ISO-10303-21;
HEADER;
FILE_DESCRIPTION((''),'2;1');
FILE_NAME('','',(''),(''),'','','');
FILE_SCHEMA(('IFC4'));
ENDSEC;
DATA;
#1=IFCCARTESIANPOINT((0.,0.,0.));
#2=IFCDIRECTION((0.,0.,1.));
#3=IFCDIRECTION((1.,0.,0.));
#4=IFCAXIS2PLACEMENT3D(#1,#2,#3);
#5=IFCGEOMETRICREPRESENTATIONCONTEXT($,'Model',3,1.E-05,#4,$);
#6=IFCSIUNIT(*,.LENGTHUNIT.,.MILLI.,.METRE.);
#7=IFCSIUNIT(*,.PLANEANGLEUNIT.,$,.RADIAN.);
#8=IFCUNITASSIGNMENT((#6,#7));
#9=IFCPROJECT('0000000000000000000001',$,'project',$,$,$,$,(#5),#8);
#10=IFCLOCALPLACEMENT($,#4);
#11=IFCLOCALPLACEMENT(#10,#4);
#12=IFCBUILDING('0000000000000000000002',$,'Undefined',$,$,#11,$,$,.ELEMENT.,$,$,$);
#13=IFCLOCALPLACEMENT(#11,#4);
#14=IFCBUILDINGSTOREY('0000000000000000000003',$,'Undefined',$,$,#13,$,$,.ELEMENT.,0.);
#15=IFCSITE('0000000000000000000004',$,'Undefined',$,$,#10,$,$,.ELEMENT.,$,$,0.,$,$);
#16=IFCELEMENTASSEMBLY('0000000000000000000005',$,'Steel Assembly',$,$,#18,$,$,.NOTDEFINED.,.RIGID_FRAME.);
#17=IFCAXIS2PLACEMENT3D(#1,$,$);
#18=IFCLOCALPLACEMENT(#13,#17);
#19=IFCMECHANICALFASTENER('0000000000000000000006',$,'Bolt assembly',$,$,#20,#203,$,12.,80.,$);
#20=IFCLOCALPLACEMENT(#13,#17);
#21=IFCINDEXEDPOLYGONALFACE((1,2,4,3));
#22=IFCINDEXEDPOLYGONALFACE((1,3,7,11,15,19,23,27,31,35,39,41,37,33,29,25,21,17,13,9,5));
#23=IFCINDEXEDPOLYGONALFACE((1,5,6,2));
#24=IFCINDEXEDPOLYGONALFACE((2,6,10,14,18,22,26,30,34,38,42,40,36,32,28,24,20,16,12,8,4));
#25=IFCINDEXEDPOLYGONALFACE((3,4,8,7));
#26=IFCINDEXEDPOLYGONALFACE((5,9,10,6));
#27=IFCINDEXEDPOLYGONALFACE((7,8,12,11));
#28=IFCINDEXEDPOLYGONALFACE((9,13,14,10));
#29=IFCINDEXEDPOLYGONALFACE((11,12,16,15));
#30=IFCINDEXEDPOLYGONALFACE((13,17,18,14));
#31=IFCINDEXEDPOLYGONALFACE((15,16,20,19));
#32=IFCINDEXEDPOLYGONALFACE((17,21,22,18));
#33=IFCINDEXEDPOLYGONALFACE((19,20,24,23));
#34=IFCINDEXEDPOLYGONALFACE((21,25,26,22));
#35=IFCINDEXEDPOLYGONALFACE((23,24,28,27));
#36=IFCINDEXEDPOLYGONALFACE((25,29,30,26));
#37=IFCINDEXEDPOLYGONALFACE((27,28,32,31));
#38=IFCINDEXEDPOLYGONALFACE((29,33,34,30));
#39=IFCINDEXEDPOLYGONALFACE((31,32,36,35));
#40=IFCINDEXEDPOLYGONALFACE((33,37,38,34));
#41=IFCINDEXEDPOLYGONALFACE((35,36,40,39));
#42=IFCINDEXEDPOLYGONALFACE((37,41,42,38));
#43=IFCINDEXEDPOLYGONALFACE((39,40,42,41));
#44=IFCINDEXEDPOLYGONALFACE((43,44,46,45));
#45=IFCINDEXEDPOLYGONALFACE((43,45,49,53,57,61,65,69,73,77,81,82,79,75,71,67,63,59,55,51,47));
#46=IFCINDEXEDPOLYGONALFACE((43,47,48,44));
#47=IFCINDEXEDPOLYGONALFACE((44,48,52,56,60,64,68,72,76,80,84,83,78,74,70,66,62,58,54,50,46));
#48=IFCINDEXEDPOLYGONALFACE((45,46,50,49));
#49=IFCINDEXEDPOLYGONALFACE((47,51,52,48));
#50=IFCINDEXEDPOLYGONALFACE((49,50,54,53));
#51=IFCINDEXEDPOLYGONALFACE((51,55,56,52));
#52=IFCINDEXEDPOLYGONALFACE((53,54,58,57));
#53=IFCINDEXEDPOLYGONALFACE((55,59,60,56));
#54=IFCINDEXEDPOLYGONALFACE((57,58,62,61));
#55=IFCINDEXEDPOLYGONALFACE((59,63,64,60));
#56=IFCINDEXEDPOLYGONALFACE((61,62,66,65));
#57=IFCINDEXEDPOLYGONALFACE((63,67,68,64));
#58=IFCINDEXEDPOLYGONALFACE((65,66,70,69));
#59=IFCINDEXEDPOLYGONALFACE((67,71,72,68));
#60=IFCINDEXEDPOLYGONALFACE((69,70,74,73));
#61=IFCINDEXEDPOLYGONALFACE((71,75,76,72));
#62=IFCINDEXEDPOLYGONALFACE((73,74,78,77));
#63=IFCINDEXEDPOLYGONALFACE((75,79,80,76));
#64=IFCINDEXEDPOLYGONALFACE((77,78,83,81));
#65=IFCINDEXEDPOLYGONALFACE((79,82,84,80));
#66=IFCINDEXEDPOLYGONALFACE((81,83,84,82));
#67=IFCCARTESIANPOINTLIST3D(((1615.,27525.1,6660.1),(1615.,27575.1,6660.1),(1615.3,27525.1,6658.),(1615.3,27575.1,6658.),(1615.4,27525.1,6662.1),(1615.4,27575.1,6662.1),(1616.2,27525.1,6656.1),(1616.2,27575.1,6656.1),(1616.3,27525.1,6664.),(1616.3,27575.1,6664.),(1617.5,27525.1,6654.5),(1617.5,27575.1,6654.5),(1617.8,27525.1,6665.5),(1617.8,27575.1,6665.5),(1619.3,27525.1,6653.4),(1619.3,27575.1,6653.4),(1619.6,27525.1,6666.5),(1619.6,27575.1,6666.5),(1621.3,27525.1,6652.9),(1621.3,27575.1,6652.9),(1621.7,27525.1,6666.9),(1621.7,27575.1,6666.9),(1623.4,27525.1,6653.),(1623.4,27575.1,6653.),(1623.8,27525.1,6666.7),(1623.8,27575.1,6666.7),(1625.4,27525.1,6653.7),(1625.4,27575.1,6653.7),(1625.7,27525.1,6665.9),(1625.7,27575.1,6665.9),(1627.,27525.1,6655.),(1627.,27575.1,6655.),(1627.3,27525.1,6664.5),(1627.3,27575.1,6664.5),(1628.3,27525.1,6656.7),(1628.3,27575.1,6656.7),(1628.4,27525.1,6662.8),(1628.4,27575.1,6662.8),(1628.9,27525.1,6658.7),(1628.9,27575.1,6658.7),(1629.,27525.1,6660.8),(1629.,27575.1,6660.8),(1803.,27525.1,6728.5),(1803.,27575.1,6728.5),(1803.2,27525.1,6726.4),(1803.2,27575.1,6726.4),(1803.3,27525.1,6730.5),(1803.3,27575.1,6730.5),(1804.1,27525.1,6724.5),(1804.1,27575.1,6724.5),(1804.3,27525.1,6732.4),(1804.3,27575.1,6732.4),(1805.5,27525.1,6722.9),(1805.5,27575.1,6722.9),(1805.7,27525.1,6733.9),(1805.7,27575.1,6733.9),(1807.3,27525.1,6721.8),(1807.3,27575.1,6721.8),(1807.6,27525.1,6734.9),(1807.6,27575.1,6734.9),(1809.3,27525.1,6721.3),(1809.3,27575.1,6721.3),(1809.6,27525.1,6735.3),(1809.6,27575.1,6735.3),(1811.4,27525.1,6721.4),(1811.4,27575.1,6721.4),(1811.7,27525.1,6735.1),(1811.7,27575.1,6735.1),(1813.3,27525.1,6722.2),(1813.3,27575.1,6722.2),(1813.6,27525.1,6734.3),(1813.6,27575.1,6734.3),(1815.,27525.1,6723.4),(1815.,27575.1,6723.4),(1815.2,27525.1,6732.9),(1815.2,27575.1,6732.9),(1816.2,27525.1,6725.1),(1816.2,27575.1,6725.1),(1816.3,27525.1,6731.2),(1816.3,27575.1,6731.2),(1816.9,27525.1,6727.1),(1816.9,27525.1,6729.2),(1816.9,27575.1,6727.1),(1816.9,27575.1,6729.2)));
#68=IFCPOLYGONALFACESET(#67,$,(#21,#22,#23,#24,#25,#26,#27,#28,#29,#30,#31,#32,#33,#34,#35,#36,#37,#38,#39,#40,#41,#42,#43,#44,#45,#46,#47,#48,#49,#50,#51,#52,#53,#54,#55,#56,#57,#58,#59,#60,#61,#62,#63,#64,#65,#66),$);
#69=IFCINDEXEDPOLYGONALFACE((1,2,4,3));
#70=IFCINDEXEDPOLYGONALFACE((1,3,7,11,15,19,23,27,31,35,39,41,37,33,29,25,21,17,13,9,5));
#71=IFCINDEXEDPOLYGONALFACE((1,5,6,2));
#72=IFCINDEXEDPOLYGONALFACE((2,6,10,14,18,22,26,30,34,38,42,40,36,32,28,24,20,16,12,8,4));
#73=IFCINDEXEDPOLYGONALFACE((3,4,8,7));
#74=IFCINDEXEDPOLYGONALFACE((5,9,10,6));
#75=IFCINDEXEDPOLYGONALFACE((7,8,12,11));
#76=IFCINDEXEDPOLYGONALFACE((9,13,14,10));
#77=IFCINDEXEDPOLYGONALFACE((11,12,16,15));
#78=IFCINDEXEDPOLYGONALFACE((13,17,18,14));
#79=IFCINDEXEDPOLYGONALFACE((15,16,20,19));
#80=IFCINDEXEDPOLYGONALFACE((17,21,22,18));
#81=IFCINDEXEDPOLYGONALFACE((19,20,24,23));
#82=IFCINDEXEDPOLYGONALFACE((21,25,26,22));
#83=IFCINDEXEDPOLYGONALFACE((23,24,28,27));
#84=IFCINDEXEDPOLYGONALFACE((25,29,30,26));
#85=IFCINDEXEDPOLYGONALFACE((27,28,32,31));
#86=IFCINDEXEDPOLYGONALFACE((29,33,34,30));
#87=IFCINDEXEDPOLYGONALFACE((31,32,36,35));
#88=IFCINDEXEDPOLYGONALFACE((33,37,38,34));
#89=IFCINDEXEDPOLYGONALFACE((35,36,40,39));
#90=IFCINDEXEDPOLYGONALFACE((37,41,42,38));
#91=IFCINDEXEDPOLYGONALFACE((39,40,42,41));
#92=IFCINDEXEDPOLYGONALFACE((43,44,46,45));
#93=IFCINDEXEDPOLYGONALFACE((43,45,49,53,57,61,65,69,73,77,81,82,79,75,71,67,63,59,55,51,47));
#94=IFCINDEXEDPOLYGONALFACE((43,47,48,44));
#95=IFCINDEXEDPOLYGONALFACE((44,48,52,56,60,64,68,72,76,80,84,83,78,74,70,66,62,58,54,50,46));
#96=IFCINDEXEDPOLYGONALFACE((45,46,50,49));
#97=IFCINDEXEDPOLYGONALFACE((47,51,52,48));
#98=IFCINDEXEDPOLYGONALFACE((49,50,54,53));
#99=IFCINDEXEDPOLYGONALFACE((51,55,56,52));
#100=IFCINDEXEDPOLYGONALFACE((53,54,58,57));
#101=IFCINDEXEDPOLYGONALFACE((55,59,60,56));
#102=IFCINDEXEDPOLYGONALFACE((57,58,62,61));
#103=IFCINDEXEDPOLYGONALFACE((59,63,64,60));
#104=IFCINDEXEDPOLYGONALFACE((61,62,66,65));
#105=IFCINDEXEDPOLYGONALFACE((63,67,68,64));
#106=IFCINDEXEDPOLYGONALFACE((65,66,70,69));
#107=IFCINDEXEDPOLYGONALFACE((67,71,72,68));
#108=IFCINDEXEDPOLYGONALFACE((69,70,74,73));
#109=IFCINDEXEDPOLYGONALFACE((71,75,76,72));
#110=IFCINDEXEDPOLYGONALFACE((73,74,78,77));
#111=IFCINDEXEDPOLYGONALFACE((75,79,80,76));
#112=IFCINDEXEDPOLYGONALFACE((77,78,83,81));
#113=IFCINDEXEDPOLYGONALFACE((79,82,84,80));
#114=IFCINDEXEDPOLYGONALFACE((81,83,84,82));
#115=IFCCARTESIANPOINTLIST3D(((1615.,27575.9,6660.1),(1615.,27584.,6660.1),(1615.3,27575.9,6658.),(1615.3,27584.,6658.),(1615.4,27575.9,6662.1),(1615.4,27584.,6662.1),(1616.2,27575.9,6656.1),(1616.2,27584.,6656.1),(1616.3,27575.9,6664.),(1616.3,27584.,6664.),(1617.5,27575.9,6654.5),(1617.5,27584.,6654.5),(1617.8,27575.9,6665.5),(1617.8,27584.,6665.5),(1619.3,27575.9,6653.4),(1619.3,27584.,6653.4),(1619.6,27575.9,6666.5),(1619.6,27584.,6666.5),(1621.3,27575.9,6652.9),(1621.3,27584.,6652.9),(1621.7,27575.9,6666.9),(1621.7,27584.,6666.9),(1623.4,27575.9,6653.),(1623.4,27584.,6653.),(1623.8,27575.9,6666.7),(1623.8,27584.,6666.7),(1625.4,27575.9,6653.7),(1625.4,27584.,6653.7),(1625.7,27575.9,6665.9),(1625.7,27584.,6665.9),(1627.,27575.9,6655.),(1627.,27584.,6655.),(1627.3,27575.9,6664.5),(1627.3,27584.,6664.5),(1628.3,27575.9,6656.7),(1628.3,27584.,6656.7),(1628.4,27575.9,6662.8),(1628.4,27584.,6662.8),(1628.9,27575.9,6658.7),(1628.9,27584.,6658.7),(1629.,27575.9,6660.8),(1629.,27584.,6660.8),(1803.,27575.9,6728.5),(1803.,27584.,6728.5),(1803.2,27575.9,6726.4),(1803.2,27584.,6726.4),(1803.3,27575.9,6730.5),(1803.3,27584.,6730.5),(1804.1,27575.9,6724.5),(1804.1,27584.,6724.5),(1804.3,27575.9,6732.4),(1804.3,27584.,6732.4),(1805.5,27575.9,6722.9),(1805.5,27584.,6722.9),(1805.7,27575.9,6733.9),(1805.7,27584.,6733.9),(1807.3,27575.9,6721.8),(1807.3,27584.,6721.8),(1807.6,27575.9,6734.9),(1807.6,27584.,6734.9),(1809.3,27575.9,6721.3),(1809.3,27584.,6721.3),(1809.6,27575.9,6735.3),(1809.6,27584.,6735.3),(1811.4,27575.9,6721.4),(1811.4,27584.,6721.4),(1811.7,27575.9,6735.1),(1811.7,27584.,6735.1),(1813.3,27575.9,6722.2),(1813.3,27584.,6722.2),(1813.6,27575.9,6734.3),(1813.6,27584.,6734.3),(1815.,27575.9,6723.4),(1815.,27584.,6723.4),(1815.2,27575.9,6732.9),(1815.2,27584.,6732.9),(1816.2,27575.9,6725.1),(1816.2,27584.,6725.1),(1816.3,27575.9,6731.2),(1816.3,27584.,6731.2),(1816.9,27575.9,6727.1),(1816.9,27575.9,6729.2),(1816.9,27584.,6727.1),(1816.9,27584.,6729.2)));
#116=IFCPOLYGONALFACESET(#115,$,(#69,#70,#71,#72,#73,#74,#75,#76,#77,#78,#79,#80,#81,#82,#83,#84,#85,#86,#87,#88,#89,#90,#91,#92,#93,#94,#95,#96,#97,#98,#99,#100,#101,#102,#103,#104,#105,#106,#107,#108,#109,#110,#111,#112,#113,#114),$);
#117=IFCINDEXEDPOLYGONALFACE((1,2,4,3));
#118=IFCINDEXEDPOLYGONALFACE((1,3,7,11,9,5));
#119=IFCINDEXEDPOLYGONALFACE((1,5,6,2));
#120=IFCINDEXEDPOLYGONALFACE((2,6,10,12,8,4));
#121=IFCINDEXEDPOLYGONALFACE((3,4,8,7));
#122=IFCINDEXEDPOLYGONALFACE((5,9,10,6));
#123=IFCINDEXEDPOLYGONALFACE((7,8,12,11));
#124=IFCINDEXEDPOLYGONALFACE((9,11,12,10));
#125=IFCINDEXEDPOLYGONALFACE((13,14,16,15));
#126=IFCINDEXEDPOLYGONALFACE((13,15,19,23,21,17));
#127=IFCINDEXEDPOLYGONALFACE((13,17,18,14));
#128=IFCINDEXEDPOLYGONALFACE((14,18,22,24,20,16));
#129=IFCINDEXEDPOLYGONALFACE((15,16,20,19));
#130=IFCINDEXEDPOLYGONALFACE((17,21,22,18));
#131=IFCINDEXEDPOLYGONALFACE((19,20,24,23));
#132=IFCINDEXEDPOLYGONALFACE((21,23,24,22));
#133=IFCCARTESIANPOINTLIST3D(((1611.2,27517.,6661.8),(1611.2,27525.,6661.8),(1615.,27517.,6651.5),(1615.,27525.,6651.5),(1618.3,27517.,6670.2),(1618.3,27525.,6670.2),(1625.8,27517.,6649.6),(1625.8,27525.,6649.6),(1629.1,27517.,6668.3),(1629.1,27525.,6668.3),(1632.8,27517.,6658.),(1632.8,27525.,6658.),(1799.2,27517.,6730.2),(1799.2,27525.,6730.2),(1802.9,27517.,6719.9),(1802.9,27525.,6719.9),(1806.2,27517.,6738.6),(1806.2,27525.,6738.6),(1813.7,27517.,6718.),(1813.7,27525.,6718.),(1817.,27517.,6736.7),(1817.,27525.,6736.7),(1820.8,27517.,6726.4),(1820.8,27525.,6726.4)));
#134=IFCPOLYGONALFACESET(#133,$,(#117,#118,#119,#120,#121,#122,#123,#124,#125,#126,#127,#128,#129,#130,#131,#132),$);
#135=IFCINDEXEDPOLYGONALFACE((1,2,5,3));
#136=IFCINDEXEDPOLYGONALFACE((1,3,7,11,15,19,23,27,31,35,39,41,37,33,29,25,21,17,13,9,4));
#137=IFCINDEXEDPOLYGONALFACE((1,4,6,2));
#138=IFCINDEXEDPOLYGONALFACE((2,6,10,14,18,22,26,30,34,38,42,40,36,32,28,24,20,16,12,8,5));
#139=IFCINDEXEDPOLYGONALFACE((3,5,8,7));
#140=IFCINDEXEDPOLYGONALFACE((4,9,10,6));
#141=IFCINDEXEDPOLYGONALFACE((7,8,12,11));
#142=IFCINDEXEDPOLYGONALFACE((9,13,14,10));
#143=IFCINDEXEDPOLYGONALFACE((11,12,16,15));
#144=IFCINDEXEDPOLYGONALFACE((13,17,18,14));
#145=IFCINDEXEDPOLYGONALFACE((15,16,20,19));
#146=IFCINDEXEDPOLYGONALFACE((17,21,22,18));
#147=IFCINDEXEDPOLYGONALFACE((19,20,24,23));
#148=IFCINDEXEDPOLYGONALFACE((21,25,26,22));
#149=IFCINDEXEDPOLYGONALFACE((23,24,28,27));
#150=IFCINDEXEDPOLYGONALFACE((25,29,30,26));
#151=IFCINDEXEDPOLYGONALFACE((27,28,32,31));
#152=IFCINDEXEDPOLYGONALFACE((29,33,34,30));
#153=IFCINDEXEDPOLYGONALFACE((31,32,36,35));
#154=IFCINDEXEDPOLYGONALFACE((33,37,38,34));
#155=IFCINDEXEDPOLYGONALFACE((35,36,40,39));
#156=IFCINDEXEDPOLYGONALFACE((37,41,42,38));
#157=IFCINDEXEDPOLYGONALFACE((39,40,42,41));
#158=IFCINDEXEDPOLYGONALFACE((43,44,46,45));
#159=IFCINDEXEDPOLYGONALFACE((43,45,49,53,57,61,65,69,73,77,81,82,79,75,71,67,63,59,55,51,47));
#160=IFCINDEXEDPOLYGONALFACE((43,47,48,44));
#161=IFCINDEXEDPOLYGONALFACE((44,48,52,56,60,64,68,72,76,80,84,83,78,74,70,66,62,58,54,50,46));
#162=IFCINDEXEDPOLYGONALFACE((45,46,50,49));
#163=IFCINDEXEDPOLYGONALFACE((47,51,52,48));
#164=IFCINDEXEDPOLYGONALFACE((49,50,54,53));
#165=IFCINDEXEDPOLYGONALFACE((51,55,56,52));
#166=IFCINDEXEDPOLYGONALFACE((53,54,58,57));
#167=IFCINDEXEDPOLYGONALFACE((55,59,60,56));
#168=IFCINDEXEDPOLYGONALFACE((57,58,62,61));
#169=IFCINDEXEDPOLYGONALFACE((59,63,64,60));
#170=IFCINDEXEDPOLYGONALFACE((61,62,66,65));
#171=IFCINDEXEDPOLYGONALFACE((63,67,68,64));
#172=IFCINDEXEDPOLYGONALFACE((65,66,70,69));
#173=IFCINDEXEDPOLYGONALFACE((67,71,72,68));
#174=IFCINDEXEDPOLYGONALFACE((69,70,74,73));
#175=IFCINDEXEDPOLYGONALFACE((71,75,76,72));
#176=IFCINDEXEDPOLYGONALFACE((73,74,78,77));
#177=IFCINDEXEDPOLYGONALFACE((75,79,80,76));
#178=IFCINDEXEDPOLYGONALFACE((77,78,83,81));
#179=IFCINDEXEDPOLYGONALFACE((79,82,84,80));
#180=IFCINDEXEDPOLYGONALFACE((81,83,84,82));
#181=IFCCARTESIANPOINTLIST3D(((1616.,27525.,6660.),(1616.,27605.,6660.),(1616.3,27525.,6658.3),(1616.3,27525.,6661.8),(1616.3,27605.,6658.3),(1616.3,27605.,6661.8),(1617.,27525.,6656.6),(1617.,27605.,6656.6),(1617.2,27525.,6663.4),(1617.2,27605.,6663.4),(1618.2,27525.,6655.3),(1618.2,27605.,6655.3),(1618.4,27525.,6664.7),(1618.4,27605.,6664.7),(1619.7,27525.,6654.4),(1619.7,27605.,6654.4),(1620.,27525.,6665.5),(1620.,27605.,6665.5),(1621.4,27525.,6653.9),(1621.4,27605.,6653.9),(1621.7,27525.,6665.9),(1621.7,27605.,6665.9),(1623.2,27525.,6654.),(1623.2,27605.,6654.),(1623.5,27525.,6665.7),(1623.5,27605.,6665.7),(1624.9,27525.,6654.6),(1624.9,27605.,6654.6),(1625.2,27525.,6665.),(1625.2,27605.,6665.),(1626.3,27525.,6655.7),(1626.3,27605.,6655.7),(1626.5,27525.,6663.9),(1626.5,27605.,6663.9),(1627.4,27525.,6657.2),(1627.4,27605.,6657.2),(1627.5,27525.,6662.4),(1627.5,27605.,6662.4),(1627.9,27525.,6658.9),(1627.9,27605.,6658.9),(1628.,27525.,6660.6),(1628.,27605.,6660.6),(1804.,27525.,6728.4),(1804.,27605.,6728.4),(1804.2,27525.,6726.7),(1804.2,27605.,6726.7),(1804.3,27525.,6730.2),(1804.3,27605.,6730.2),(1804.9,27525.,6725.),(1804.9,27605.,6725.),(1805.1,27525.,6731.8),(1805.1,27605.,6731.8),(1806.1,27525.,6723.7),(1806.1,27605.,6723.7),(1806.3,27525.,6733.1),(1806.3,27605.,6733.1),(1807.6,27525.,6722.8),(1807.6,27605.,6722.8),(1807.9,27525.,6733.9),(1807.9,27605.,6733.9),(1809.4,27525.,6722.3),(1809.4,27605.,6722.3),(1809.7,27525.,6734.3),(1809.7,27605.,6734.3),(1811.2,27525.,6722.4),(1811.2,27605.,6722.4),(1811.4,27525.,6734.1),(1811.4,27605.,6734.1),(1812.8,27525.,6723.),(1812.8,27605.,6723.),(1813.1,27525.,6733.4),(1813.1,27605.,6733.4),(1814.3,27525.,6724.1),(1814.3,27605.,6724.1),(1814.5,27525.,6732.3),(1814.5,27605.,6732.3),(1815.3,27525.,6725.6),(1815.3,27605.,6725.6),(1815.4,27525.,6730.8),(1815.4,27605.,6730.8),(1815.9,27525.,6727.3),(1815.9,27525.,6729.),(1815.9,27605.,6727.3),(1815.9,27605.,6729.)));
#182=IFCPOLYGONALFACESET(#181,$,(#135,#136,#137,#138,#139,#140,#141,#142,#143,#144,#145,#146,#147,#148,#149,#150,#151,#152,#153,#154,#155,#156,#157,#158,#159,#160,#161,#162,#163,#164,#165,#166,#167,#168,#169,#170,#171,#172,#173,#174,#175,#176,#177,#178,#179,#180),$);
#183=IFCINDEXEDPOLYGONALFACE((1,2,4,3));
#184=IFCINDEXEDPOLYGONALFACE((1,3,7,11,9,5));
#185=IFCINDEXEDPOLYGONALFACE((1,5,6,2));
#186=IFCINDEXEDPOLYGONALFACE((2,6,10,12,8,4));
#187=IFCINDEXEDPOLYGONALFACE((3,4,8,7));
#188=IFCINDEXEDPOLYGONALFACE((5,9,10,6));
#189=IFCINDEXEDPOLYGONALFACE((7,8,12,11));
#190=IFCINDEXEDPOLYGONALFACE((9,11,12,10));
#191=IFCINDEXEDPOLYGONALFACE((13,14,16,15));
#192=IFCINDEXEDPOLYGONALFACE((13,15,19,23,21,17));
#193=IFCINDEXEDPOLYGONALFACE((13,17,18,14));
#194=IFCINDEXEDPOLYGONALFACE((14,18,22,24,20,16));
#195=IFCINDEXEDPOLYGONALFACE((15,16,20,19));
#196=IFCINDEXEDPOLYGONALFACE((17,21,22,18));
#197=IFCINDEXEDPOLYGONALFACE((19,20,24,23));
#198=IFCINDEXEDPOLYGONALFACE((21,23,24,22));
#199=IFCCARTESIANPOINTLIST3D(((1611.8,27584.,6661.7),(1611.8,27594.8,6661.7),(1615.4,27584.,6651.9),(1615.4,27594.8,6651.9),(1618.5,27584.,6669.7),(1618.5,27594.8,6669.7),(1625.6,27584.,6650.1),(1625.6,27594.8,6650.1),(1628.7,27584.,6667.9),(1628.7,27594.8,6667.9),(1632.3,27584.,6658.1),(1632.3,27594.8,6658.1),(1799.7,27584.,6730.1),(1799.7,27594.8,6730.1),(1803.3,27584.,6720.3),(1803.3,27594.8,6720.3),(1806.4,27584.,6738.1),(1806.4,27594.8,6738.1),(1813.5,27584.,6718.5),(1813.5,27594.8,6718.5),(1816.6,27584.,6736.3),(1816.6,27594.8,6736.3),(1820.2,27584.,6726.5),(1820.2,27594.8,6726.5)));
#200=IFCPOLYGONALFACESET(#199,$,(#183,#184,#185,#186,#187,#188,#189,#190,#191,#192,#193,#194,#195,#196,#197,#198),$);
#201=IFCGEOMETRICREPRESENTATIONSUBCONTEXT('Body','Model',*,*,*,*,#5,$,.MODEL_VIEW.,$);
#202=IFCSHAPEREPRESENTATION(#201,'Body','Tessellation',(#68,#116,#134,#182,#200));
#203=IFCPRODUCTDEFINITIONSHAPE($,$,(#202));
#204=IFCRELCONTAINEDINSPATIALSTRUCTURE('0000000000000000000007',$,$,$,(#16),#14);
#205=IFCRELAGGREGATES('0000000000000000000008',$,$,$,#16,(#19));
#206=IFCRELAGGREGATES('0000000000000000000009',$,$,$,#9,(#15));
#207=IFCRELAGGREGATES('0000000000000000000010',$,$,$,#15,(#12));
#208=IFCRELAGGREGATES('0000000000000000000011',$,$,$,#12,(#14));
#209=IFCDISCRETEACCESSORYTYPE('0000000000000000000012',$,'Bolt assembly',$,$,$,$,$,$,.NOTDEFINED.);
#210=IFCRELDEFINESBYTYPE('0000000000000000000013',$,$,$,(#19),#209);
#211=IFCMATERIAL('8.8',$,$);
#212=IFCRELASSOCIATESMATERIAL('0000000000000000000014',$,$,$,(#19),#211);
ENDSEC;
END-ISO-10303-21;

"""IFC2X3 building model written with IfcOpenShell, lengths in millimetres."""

from ifc_helpers import new_model, si_unit, frame, origin_with_axes, origin_2d_with_axis, place, context, subcontext, project, spatial, polyline, circle, outline, extrude, source, transform, mapped, material, type_object, element, aggregate, save


model = new_model("IFC2X3")

# Units and contexts
model_context = context("Model", 3, precision=1e-05, world=origin_with_axes())
body_context = subcontext(model_context, "Body", "Model", "MODEL_VIEW")
ifc_project = project(units=[si_unit("LENGTHUNIT", "METRE", prefix="MILLI"), si_unit("PLANEANGLEUNIT", "RADIAN")], contexts=[model_context])

# Site, building, storey
site_placement = place(None, origin_with_axes())
site = spatial("IfcSite", under=ifc_project, at=site_placement, Name="Undefined", CompositionType="ELEMENT", RefElevation=0.0)
building_placement = place(site_placement, origin_with_axes())
building = spatial("IfcBuilding", under=site, at=building_placement, Name="Undefined", CompositionType="ELEMENT")
storey_placement = place(building_placement, origin_with_axes())
storey = spatial("IfcBuildingStorey", under=building, at=storey_placement, Name="Undefined", CompositionType="ELEMENT", Elevation=0.0)

# Element assembly, mechanical fastener
assembly_1_placement = place(storey_placement, origin_with_axes())
assembly_1 = element("IfcElementAssembly", 1, at=assembly_1_placement, inside=storey, Name="Steel Assembly", AssemblyPlace="NOTDEFINED", PredefinedType="RIGID_FRAME")
ifc_material_1 = material(Name="8.8")
discrete_accessory_type_1 = type_object("IfcDiscreteAccessoryType", Name="Bolt assembly")
shared_shape_1 = source(origin_with_axes(), body_context, "Body", "SweptSolid", [
    extrude(circle(Radius=7.0, at=origin_2d_with_axis()), frame((0.0, -52.9, 0.0), z_axis=(0.0, 1.0, 0.0), x_axis=(1.0, 0.0, 0.0)), (0.0, 0.0, 1.0), 50.0),
    extrude(circle(Radius=7.0, at=origin_2d_with_axis()), frame((0.0, -2.1, 0.0), z_axis=(0.0, 1.0, 0.0), x_axis=(1.0, 0.0, 0.0)), (0.0, 0.0, 1.0), 8.1),
    extrude(outline(polyline([(11.0, 0.0), (5.5, 9.5), (-5.5, 9.5), (-11.0, 0.0), (-5.5, -9.5), (5.5, -9.5), (11.0, 0.0)])), frame((0.0, -61.0, 0.0), z_axis=(0.0, 1.0, 0.0), x_axis=(1.0, 0.0, 0.0)), (0.0, 0.0, 1.0), 8.0),
    extrude(circle(Radius=6.0, at=origin_2d_with_axis()), frame((0.0, -53.0, 0.0), z_axis=(0.0, 1.0, 0.0), x_axis=(1.0, 0.0, 0.0)), (0.0, 0.0, 1.0), 80.0),
    extrude(outline(polyline([(10.4, 0.0), (5.2, 9.0), (-5.2, 9.0), (-10.4, 0.0), (-5.2, -9.0), (5.2, -9.0), (10.4, 0.0)])), frame((0.0, 6.0, 0.0), z_axis=(0.0, 1.0, 0.0), x_axis=(1.0, 0.0, 0.0)), (0.0, 0.0, 1.0), 10.8),
])
mechanical_fastener_1_placement = place(assembly_1_placement, frame((1732.6, 27578.0, 6648.5), z_axis=(-0.939693, 0.0, -0.34202), x_axis=(-0.34202, 0.0, 0.939693)))
mechanical_fastener_1 = element("IfcMechanicalFastener", 2, at=mechanical_fastener_1_placement, type_object=discrete_accessory_type_1, material=ifc_material_1, Name="Bolt assembly", NominalDiameter=12.0, NominalLength=80.0, context=body_context, shape_type="MappedRepresentation", body=[
    mapped(shared_shape_1, transform((48.5, 0.0, -100.0))),
    mapped(shared_shape_1, transform((48.5, 0.0, 100.0))),
])
aggregate(assembly_1, [mechanical_fastener_1])

save(model, "model.ifc")
